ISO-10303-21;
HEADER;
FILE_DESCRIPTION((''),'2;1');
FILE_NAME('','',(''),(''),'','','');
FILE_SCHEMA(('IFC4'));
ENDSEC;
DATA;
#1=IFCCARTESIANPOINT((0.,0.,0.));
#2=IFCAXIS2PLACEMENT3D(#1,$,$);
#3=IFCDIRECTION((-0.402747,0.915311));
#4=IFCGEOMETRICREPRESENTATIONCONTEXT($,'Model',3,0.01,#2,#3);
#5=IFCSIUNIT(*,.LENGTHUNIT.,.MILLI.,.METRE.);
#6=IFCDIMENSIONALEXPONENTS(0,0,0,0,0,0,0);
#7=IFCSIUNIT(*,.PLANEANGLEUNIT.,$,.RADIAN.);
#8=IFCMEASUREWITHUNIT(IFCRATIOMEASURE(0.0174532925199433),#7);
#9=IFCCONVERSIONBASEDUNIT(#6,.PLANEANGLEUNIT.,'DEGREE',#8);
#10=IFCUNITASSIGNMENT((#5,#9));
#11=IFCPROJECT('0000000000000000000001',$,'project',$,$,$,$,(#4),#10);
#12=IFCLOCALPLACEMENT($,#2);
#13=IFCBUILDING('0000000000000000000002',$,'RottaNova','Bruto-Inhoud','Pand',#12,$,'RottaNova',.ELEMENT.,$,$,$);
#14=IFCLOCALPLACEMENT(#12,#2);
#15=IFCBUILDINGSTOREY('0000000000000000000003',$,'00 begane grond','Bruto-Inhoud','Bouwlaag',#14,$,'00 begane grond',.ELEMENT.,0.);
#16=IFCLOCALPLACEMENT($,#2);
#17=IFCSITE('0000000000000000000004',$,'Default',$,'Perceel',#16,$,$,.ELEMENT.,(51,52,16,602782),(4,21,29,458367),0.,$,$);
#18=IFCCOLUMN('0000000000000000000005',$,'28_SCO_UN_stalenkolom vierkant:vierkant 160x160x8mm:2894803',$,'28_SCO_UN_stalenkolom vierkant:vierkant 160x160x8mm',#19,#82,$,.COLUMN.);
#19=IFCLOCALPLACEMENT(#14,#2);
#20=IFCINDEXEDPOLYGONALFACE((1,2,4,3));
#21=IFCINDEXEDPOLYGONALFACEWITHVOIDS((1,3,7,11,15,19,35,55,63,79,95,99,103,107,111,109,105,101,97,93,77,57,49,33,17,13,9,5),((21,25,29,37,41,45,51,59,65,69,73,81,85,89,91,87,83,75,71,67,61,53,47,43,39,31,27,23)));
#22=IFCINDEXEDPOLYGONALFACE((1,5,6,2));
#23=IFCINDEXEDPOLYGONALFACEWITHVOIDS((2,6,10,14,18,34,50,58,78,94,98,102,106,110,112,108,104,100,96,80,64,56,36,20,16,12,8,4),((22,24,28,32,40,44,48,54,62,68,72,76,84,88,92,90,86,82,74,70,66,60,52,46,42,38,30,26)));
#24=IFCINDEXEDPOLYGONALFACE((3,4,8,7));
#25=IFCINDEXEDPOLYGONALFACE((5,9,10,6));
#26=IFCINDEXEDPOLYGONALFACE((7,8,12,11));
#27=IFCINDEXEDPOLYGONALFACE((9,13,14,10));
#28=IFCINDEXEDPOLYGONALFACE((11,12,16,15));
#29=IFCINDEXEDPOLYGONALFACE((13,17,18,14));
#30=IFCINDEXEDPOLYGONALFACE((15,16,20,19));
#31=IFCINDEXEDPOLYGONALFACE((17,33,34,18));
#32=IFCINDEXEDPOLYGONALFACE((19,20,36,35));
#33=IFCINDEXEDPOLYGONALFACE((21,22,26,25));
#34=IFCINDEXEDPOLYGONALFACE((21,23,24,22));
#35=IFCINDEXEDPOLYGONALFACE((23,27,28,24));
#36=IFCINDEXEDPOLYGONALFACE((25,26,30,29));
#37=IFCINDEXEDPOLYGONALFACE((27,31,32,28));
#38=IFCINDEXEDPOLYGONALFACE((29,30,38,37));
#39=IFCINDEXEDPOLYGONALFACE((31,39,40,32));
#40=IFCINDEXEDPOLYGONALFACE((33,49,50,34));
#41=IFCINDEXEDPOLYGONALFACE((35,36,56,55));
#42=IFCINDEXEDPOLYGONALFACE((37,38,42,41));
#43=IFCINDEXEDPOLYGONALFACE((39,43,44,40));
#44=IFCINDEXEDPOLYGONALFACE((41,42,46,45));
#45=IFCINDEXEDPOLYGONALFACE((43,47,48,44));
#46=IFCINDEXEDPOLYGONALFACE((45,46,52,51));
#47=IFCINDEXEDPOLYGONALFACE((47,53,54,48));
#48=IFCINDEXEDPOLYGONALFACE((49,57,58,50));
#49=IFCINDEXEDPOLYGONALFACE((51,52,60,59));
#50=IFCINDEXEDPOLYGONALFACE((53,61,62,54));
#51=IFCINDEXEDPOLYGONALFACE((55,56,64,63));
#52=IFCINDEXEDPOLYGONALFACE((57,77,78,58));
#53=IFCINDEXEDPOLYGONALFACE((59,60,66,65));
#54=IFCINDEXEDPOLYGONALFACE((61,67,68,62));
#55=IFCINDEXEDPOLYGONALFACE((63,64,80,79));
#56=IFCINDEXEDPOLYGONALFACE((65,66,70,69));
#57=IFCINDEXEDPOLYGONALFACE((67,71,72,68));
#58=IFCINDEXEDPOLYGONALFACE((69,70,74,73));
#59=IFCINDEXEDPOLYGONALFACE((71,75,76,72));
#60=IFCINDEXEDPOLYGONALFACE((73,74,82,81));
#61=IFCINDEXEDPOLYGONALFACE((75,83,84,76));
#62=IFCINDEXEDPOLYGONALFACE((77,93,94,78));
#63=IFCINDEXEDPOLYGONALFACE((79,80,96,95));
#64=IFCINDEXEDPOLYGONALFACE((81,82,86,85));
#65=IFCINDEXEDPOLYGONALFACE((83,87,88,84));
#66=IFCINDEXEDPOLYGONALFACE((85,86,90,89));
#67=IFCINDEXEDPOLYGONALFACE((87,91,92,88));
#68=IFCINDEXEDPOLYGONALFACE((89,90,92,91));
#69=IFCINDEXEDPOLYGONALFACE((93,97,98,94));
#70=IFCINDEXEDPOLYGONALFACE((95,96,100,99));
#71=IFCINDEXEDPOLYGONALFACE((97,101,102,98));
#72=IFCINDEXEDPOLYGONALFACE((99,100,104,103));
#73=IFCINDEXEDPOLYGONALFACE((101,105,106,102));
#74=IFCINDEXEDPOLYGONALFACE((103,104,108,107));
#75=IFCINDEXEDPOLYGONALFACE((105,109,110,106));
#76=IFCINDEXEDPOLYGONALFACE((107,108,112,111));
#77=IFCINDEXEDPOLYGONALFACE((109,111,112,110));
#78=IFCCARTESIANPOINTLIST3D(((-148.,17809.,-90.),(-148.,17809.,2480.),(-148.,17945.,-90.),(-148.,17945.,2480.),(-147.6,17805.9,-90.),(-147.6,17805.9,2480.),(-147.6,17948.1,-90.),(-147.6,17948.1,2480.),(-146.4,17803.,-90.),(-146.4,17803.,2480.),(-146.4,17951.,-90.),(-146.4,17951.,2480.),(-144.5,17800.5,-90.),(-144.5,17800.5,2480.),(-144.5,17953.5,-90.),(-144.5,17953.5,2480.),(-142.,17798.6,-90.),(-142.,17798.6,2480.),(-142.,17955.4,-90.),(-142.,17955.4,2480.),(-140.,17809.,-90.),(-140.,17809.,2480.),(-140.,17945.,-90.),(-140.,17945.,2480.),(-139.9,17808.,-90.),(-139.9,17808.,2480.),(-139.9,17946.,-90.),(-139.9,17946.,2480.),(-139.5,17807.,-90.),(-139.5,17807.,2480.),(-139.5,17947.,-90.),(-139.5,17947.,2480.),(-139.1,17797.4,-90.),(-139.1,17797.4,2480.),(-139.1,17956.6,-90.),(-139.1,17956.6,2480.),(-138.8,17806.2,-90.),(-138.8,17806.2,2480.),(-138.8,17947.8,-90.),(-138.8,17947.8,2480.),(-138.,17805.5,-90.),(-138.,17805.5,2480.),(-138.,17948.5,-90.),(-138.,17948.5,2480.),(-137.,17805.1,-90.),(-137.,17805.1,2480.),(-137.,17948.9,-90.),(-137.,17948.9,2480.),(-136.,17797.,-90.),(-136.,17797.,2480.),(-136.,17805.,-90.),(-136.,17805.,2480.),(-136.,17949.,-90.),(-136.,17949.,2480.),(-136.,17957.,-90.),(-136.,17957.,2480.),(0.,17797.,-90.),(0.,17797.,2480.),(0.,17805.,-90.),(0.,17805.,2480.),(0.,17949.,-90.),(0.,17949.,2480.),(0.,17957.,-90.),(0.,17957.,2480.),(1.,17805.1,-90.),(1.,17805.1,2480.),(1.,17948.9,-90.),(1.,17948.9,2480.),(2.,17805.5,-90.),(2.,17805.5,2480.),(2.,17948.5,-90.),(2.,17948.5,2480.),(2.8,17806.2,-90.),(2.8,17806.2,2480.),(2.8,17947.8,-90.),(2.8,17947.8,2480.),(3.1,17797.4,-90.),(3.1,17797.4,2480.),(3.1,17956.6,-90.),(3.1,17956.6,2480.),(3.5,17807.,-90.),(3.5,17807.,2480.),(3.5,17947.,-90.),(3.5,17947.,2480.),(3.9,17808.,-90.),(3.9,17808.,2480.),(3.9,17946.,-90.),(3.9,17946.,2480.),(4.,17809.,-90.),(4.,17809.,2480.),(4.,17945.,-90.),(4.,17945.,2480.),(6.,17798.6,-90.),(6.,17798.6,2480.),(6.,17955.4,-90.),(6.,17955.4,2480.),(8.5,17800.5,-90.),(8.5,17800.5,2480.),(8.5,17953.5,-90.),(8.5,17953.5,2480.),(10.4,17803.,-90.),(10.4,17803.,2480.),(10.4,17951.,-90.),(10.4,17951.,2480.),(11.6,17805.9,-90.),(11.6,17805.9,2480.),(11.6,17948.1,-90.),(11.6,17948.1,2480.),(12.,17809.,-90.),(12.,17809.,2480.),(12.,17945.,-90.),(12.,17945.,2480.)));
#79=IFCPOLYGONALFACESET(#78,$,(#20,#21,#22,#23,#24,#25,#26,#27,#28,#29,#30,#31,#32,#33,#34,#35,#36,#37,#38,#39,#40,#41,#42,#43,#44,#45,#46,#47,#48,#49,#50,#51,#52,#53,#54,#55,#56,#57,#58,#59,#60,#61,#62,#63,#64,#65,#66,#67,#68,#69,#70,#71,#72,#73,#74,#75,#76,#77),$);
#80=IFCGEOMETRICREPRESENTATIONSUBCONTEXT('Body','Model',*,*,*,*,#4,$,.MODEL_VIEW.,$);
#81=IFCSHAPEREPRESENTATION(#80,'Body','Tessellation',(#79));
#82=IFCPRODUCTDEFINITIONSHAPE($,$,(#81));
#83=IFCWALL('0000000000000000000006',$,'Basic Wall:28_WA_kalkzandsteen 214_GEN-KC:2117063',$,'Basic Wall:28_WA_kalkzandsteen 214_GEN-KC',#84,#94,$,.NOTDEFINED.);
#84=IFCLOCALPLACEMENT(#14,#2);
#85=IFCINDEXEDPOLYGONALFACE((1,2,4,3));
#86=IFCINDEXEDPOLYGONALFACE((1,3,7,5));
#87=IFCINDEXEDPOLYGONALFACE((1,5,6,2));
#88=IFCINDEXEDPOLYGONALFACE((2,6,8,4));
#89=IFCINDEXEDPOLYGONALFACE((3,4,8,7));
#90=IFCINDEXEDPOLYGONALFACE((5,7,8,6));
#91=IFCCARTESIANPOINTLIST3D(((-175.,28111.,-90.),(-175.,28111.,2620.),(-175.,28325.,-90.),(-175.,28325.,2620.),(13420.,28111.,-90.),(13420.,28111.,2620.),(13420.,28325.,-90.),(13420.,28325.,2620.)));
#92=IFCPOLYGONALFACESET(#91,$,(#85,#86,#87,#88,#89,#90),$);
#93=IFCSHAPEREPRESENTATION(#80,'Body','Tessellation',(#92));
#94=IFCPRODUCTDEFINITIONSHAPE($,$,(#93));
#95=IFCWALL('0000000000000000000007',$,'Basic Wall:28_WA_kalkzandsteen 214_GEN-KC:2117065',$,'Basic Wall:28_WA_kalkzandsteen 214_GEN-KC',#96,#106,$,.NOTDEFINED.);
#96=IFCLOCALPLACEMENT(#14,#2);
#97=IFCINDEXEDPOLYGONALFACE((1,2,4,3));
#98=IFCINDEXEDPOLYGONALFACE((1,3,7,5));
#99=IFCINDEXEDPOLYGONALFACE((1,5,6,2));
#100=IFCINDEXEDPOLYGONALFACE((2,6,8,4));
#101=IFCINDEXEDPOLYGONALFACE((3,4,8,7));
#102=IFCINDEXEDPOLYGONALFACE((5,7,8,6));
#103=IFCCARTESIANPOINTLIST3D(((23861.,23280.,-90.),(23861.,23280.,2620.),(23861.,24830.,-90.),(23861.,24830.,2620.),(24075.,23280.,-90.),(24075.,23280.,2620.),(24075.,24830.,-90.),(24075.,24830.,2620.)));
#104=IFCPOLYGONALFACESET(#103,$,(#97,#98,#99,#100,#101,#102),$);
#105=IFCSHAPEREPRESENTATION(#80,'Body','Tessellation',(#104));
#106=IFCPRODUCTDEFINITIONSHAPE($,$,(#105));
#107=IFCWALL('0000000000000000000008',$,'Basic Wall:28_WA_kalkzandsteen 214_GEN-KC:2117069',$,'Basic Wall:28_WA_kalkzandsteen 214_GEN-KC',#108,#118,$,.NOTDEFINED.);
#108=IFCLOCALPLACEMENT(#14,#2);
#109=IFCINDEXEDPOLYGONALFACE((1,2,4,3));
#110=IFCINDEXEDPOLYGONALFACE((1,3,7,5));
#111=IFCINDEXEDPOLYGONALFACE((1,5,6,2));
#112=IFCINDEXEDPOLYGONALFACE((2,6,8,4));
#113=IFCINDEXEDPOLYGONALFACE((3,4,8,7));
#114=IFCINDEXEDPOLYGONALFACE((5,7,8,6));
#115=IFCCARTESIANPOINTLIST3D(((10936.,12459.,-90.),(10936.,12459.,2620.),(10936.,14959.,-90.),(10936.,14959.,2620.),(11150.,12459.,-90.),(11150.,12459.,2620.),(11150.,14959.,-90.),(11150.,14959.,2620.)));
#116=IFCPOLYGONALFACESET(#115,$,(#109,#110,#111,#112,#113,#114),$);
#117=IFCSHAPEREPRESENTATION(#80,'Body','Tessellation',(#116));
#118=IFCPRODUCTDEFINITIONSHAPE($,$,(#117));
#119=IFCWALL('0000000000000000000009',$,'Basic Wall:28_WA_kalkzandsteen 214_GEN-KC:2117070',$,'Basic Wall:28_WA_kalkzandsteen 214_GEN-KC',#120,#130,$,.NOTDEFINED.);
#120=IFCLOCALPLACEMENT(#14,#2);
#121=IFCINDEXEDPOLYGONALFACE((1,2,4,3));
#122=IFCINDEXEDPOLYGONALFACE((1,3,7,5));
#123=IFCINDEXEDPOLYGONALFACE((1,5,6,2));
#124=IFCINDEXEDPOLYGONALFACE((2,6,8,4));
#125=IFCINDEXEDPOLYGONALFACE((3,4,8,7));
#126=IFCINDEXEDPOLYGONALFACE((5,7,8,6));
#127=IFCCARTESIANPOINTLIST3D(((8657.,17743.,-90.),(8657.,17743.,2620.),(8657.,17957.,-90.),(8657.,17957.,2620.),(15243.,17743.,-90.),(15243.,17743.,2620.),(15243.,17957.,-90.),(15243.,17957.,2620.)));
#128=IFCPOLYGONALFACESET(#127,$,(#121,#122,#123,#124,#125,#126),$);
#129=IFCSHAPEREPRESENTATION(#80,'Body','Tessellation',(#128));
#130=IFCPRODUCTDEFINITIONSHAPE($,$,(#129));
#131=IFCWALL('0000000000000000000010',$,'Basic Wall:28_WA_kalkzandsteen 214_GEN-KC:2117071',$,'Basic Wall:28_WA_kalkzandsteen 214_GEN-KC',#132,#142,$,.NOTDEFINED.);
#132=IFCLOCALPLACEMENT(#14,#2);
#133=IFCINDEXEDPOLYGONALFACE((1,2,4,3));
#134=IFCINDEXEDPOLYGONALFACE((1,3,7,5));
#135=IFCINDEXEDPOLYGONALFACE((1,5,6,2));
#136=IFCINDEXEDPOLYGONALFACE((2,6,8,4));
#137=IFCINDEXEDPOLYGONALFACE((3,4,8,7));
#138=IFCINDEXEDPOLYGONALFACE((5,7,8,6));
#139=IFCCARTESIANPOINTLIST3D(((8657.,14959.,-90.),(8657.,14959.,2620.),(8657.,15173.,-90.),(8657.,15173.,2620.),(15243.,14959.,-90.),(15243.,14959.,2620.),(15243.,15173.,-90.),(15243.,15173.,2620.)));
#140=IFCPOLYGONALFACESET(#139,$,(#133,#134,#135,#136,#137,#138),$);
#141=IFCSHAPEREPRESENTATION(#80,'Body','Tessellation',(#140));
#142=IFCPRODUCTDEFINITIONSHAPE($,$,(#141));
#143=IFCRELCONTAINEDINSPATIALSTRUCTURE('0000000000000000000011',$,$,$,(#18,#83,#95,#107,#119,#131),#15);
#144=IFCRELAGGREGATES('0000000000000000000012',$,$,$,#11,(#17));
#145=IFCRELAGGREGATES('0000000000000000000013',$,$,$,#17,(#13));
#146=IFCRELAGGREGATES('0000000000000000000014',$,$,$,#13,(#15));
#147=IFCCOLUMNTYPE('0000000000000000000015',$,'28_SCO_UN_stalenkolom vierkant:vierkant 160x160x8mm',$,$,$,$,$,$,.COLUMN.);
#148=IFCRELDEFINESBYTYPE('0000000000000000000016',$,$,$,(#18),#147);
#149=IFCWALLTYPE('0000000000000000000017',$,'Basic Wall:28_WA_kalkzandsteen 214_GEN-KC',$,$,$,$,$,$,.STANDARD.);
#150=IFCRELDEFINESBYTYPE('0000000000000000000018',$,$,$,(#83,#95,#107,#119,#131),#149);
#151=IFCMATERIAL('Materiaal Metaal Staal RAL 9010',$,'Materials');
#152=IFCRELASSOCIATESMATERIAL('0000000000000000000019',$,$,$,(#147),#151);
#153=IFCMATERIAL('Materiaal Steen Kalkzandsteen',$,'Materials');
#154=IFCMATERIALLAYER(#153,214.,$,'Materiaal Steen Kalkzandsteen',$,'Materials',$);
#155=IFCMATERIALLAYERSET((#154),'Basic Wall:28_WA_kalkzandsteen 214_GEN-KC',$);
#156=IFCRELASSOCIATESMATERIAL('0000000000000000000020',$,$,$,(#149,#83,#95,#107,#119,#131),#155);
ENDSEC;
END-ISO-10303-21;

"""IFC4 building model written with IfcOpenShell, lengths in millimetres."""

from ifc_helpers import new_model, entity, si_unit, converted_unit, direction, frame, frame_2d, origin, place, context, subcontext, project, spatial, polyline, circle_curve, parameter, trimmed, segment, composite_curve, rectangle, outline, extrude, source, transform, mapped, material, layer, layer_set, material_profile, profile_set, type_object, type_shapes, element, save


model = new_model("IFC4")

# Units and contexts
model_context = context("Model", 3, precision=0.01, world=origin(), true_north=direction((-0.402747, 0.915311)))
body_context = subcontext(model_context, "Body", "Model", "MODEL_VIEW")
ifc_project = project(units=[si_unit("LENGTHUNIT", "METRE", prefix="MILLI"), converted_unit("PLANEANGLEUNIT", "DEGREE", entity("IfcRatioMeasure", 0.0174532925199433), si_unit("PLANEANGLEUNIT", "RADIAN"), dimensions=[0, 0, 0, 0, 0, 0, 0])], contexts=[model_context])

# Site, building, storey
site_placement = place(None, origin())
site = spatial("IfcSite", under=ifc_project, at=site_placement, Name="Default", ObjectType="Perceel", CompositionType="ELEMENT", RefLatitude=(51, 52, 16, 602782), RefLongitude=(4, 21, 29, 458367), RefElevation=0.0)
building_placement = place(None, origin())
building = spatial("IfcBuilding", under=site, at=building_placement, Name="RottaNova", Description="Bruto-Inhoud", ObjectType="Pand", LongName="RottaNova", CompositionType="ELEMENT")
storey_placement = place(building_placement, origin())
storey = spatial("IfcBuildingStorey", under=building, at=storey_placement, Name="00 begane grond", Description="Bruto-Inhoud", ObjectType="Bouwlaag", LongName="00 begane grond", CompositionType="ELEMENT", Elevation=0.0)

# Column
ifc_material_1 = material(Name="Materiaal Metaal Staal RAL 9010", Category="Materials")
ifc_material_profile_1 = material_profile(ifc_material_1, outline(composite_curve([segment(polyline([(-68.0, -80.0), (68.0, -80.0)]), True, "CONTINUOUS"), segment(trimmed(circle_curve(frame_2d((68.0, -68.0), x_axis=(-1.0, 0.0)), 12.0), [parameter(90.0)], [parameter(180.0)], True, "PARAMETER"), True, "CONTINUOUS"), segment(polyline([(80.0, -68.0), (80.0, 68.0)]), True, "CONTINUOUS"), segment(trimmed(circle_curve(frame_2d((68.0, 68.0), x_axis=(-1.0, 0.0)), 12.0), [parameter(180.0)], [parameter(270.0)], True, "PARAMETER"), True, "CONTINUOUS"), segment(polyline([(68.0, 80.0), (-68.0, 80.0)]), True, "CONTINUOUS"), segment(trimmed(circle_curve(frame_2d((-68.0, 68.0), x_axis=(-1.0, 0.0)), 12.0), [parameter(270.0)], [parameter(0.0)], True, "PARAMETER"), True, "CONTINUOUS"), segment(polyline([(-80.0, 68.0), (-80.0, -68.0)]), True, "CONTINUOUS"), segment(trimmed(circle_curve(frame_2d((-68.0, -68.0), x_axis=(-1.0, 0.0)), 12.0), [parameter(0.0)], [parameter(90.0)], True, "PARAMETER"), True, "CONTINUOUS")], self_intersect=False), holes=[composite_curve([segment(trimmed(circle_curve(frame_2d((68.0, -68.0), x_axis=(-1.0, 0.0)), 4.0), [parameter(90.0)], [parameter(180.0)], True, "PARAMETER"), False, "CONTINUOUS"), segment(polyline([(68.0, -72.0), (-68.0, -72.0)]), True, "CONTINUOUS"), segment(trimmed(circle_curve(frame_2d((-68.0, -68.0), x_axis=(-1.0, 0.0)), 4.0), [parameter(0.0)], [parameter(90.0)], True, "PARAMETER"), False, "CONTINUOUS"), segment(polyline([(-72.0, -68.0), (-72.0, 68.0)]), True, "CONTINUOUS"), segment(trimmed(circle_curve(frame_2d((-68.0, 68.0), x_axis=(-1.0, 0.0)), 4.0), [parameter(270.0)], [parameter(360.0)], True, "PARAMETER"), False, "CONTINUOUS"), segment(polyline([(-68.0, 72.0), (68.0, 72.0)]), True, "CONTINUOUS"), segment(trimmed(circle_curve(frame_2d((68.0, 68.0), x_axis=(-1.0, 0.0)), 4.0), [parameter(180.0)], [parameter(270.0)], True, "PARAMETER"), False, "CONTINUOUS"), segment(polyline([(72.0, 68.0), (72.0, -68.0)]), True, "CONTINUOUS")], self_intersect=False)]), Name="vierkant 160x160x8mm")
ifc_profile_set_1 = profile_set([ifc_material_profile_1], Name="vierkant 160x160x8mm")
column_type_1 = type_object("IfcColumnType", Name="28_SCO_UN_stalenkolom vierkant:vierkant 160x160x8mm", PredefinedType="COLUMN", material=ifc_profile_set_1)
shared_shape_1 = source(origin(), body_context, "Body", "SweptSolid", [
    extrude(outline(composite_curve([segment(polyline([(-68.0, -80.0), (68.0, -80.0)]), True, "CONTINUOUS"), segment(trimmed(circle_curve(frame_2d((68.0, -68.0), x_axis=(-1.0, 0.0)), 12.0), [parameter(90.0)], [parameter(180.0)], True, "PARAMETER"), True, "CONTINUOUS"), segment(polyline([(80.0, -68.0), (80.0, 68.0)]), True, "CONTINUOUS"), segment(trimmed(circle_curve(frame_2d((68.0, 68.0), x_axis=(-1.0, 0.0)), 12.0), [parameter(180.0)], [parameter(270.0)], True, "PARAMETER"), True, "CONTINUOUS"), segment(polyline([(68.0, 80.0), (-68.0, 80.0)]), True, "CONTINUOUS"), segment(trimmed(circle_curve(frame_2d((-68.0, 68.0), x_axis=(-1.0, 0.0)), 12.0), [parameter(270.0)], [parameter(0.0)], True, "PARAMETER"), True, "CONTINUOUS"), segment(polyline([(-80.0, 68.0), (-80.0, -68.0)]), True, "CONTINUOUS"), segment(trimmed(circle_curve(frame_2d((-68.0, -68.0), x_axis=(-1.0, 0.0)), 12.0), [parameter(0.0)], [parameter(90.0)], True, "PARAMETER"), True, "CONTINUOUS")], self_intersect=False), holes=[composite_curve([segment(trimmed(circle_curve(frame_2d((68.0, -68.0), x_axis=(-1.0, 0.0)), 4.0), [parameter(90.0)], [parameter(180.0)], True, "PARAMETER"), False, "CONTINUOUS"), segment(polyline([(68.0, -72.0), (-68.0, -72.0)]), True, "CONTINUOUS"), segment(trimmed(circle_curve(frame_2d((-68.0, -68.0), x_axis=(-1.0, 0.0)), 4.0), [parameter(0.0)], [parameter(90.0)], True, "PARAMETER"), False, "CONTINUOUS"), segment(polyline([(-72.0, -68.0), (-72.0, 68.0)]), True, "CONTINUOUS"), segment(trimmed(circle_curve(frame_2d((-68.0, 68.0), x_axis=(-1.0, 0.0)), 4.0), [parameter(270.0)], [parameter(360.0)], True, "PARAMETER"), False, "CONTINUOUS"), segment(polyline([(-68.0, 72.0), (68.0, 72.0)]), True, "CONTINUOUS"), segment(trimmed(circle_curve(frame_2d((68.0, 68.0), x_axis=(-1.0, 0.0)), 4.0), [parameter(180.0)], [parameter(270.0)], True, "PARAMETER"), False, "CONTINUOUS"), segment(polyline([(72.0, 68.0), (72.0, -68.0)]), True, "CONTINUOUS")], self_intersect=False)]), frame((0.0, 0.0, -90.0), z_axis=(0.0, 0.0, 1.0), x_axis=(-1.0, 0.0, 0.0)), (0.0, 0.0, 1.0), 2570.0),
])
type_shapes(column_type_1, [shared_shape_1])
column_1_placement = place(storey_placement, frame((-68.0, 17877.0, 0.0), z_axis=(0.0, 0.0, 1.0), x_axis=(-1.0, 0.0, 0.0)))
element("IfcColumn", 1, at=column_1_placement, inside=storey, type_object=column_type_1, Name="28_SCO_UN_stalenkolom vierkant:vierkant 160x160x8mm:2894803", ObjectType="28_SCO_UN_stalenkolom vierkant:vierkant 160x160x8mm", PredefinedType="COLUMN", context=body_context, shape_type="MappedRepresentation", body=[
    mapped(shared_shape_1, transform((0.0, 0.0, 0.0), scale=1.0)),
])

# Walls
ifc_material_2 = material(Name="Materiaal Steen Kalkzandsteen", Category="Materials")
ifc_layer_1 = layer(ifc_material_2, 214.0, Name="Materiaal Steen Kalkzandsteen", Category="Materials")
ifc_layer_set_1 = layer_set([ifc_layer_1], Name="Basic Wall:28_WA_kalkzandsteen 214_GEN-KC")
wall_type_1 = type_object("IfcWallType", Name="Basic Wall:28_WA_kalkzandsteen 214_GEN-KC", PredefinedType="STANDARD", material=ifc_layer_set_1)
wall_1_placement = place(storey_placement, frame((-175.0, 28218.0, -90.0)))
element("IfcWall", 2, at=wall_1_placement, inside=storey, type_object=wall_type_1, material=ifc_layer_set_1, Name="Basic Wall:28_WA_kalkzandsteen 214_GEN-KC:2117063", ObjectType="Basic Wall:28_WA_kalkzandsteen 214_GEN-KC", PredefinedType="NOTDEFINED", context=body_context, shape_type="SweptSolid", body=[
    extrude(rectangle(XDim=13595.0, YDim=214.0, at=frame_2d((6797.5, 0.0), x_axis=(-1.0, 0.0))), origin(), (0.0, 0.0, 1.0), 2710.0),
])
wall_2_placement = place(storey_placement, frame((23968.0, 24830.0, -90.0), z_axis=(0.0, 0.0, 1.0), x_axis=(0.0, -1.0, 0.0)))
element("IfcWall", 3, at=wall_2_placement, inside=storey, type_object=wall_type_1, material=ifc_layer_set_1, Name="Basic Wall:28_WA_kalkzandsteen 214_GEN-KC:2117065", ObjectType="Basic Wall:28_WA_kalkzandsteen 214_GEN-KC", PredefinedType="NOTDEFINED", context=body_context, shape_type="SweptSolid", body=[
    extrude(rectangle(XDim=1550.0, YDim=214.0, at=frame_2d((775.0, 0.0), x_axis=(-1.0, 0.0))), origin(), (0.0, 0.0, 1.0), 2710.0),
])
wall_3_placement = place(storey_placement, frame((11043.0, 12459.0, -90.0), z_axis=(0.0, 0.0, 1.0), x_axis=(0.0, 1.0, 0.0)))
element("IfcWall", 4, at=wall_3_placement, inside=storey, type_object=wall_type_1, material=ifc_layer_set_1, Name="Basic Wall:28_WA_kalkzandsteen 214_GEN-KC:2117069", ObjectType="Basic Wall:28_WA_kalkzandsteen 214_GEN-KC", PredefinedType="NOTDEFINED", context=body_context, shape_type="SweptSolid", body=[
    extrude(rectangle(XDim=2500.0, YDim=214.0, at=frame_2d((1250.0, 0.0), x_axis=(-1.0, 0.0))), origin(), (0.0, 0.0, 1.0), 2710.0),
])
wall_4_placement = place(storey_placement, frame((8657.0, 17850.0, -90.0)))
element("IfcWall", 5, at=wall_4_placement, inside=storey, type_object=wall_type_1, material=ifc_layer_set_1, Name="Basic Wall:28_WA_kalkzandsteen 214_GEN-KC:2117070", ObjectType="Basic Wall:28_WA_kalkzandsteen 214_GEN-KC", PredefinedType="NOTDEFINED", context=body_context, shape_type="SweptSolid", body=[
    extrude(rectangle(XDim=6586.0, YDim=214.0, at=frame_2d((3293.0, 0.0), x_axis=(-1.0, 0.0))), origin(), (0.0, 0.0, 1.0), 2710.0),
])
wall_5_placement = place(storey_placement, frame((8657.0, 15066.0, -90.0)))
element("IfcWall", 6, at=wall_5_placement, inside=storey, type_object=wall_type_1, material=ifc_layer_set_1, Name="Basic Wall:28_WA_kalkzandsteen 214_GEN-KC:2117071", ObjectType="Basic Wall:28_WA_kalkzandsteen 214_GEN-KC", PredefinedType="NOTDEFINED", context=body_context, shape_type="SweptSolid", body=[
    extrude(rectangle(XDim=6586.0, YDim=214.0, at=frame_2d((3293.0, 0.0), x_axis=(1.0, 0.0))), origin(), (0.0, 0.0, 1.0), 2710.0),
])

save(model, "model.ifc")
